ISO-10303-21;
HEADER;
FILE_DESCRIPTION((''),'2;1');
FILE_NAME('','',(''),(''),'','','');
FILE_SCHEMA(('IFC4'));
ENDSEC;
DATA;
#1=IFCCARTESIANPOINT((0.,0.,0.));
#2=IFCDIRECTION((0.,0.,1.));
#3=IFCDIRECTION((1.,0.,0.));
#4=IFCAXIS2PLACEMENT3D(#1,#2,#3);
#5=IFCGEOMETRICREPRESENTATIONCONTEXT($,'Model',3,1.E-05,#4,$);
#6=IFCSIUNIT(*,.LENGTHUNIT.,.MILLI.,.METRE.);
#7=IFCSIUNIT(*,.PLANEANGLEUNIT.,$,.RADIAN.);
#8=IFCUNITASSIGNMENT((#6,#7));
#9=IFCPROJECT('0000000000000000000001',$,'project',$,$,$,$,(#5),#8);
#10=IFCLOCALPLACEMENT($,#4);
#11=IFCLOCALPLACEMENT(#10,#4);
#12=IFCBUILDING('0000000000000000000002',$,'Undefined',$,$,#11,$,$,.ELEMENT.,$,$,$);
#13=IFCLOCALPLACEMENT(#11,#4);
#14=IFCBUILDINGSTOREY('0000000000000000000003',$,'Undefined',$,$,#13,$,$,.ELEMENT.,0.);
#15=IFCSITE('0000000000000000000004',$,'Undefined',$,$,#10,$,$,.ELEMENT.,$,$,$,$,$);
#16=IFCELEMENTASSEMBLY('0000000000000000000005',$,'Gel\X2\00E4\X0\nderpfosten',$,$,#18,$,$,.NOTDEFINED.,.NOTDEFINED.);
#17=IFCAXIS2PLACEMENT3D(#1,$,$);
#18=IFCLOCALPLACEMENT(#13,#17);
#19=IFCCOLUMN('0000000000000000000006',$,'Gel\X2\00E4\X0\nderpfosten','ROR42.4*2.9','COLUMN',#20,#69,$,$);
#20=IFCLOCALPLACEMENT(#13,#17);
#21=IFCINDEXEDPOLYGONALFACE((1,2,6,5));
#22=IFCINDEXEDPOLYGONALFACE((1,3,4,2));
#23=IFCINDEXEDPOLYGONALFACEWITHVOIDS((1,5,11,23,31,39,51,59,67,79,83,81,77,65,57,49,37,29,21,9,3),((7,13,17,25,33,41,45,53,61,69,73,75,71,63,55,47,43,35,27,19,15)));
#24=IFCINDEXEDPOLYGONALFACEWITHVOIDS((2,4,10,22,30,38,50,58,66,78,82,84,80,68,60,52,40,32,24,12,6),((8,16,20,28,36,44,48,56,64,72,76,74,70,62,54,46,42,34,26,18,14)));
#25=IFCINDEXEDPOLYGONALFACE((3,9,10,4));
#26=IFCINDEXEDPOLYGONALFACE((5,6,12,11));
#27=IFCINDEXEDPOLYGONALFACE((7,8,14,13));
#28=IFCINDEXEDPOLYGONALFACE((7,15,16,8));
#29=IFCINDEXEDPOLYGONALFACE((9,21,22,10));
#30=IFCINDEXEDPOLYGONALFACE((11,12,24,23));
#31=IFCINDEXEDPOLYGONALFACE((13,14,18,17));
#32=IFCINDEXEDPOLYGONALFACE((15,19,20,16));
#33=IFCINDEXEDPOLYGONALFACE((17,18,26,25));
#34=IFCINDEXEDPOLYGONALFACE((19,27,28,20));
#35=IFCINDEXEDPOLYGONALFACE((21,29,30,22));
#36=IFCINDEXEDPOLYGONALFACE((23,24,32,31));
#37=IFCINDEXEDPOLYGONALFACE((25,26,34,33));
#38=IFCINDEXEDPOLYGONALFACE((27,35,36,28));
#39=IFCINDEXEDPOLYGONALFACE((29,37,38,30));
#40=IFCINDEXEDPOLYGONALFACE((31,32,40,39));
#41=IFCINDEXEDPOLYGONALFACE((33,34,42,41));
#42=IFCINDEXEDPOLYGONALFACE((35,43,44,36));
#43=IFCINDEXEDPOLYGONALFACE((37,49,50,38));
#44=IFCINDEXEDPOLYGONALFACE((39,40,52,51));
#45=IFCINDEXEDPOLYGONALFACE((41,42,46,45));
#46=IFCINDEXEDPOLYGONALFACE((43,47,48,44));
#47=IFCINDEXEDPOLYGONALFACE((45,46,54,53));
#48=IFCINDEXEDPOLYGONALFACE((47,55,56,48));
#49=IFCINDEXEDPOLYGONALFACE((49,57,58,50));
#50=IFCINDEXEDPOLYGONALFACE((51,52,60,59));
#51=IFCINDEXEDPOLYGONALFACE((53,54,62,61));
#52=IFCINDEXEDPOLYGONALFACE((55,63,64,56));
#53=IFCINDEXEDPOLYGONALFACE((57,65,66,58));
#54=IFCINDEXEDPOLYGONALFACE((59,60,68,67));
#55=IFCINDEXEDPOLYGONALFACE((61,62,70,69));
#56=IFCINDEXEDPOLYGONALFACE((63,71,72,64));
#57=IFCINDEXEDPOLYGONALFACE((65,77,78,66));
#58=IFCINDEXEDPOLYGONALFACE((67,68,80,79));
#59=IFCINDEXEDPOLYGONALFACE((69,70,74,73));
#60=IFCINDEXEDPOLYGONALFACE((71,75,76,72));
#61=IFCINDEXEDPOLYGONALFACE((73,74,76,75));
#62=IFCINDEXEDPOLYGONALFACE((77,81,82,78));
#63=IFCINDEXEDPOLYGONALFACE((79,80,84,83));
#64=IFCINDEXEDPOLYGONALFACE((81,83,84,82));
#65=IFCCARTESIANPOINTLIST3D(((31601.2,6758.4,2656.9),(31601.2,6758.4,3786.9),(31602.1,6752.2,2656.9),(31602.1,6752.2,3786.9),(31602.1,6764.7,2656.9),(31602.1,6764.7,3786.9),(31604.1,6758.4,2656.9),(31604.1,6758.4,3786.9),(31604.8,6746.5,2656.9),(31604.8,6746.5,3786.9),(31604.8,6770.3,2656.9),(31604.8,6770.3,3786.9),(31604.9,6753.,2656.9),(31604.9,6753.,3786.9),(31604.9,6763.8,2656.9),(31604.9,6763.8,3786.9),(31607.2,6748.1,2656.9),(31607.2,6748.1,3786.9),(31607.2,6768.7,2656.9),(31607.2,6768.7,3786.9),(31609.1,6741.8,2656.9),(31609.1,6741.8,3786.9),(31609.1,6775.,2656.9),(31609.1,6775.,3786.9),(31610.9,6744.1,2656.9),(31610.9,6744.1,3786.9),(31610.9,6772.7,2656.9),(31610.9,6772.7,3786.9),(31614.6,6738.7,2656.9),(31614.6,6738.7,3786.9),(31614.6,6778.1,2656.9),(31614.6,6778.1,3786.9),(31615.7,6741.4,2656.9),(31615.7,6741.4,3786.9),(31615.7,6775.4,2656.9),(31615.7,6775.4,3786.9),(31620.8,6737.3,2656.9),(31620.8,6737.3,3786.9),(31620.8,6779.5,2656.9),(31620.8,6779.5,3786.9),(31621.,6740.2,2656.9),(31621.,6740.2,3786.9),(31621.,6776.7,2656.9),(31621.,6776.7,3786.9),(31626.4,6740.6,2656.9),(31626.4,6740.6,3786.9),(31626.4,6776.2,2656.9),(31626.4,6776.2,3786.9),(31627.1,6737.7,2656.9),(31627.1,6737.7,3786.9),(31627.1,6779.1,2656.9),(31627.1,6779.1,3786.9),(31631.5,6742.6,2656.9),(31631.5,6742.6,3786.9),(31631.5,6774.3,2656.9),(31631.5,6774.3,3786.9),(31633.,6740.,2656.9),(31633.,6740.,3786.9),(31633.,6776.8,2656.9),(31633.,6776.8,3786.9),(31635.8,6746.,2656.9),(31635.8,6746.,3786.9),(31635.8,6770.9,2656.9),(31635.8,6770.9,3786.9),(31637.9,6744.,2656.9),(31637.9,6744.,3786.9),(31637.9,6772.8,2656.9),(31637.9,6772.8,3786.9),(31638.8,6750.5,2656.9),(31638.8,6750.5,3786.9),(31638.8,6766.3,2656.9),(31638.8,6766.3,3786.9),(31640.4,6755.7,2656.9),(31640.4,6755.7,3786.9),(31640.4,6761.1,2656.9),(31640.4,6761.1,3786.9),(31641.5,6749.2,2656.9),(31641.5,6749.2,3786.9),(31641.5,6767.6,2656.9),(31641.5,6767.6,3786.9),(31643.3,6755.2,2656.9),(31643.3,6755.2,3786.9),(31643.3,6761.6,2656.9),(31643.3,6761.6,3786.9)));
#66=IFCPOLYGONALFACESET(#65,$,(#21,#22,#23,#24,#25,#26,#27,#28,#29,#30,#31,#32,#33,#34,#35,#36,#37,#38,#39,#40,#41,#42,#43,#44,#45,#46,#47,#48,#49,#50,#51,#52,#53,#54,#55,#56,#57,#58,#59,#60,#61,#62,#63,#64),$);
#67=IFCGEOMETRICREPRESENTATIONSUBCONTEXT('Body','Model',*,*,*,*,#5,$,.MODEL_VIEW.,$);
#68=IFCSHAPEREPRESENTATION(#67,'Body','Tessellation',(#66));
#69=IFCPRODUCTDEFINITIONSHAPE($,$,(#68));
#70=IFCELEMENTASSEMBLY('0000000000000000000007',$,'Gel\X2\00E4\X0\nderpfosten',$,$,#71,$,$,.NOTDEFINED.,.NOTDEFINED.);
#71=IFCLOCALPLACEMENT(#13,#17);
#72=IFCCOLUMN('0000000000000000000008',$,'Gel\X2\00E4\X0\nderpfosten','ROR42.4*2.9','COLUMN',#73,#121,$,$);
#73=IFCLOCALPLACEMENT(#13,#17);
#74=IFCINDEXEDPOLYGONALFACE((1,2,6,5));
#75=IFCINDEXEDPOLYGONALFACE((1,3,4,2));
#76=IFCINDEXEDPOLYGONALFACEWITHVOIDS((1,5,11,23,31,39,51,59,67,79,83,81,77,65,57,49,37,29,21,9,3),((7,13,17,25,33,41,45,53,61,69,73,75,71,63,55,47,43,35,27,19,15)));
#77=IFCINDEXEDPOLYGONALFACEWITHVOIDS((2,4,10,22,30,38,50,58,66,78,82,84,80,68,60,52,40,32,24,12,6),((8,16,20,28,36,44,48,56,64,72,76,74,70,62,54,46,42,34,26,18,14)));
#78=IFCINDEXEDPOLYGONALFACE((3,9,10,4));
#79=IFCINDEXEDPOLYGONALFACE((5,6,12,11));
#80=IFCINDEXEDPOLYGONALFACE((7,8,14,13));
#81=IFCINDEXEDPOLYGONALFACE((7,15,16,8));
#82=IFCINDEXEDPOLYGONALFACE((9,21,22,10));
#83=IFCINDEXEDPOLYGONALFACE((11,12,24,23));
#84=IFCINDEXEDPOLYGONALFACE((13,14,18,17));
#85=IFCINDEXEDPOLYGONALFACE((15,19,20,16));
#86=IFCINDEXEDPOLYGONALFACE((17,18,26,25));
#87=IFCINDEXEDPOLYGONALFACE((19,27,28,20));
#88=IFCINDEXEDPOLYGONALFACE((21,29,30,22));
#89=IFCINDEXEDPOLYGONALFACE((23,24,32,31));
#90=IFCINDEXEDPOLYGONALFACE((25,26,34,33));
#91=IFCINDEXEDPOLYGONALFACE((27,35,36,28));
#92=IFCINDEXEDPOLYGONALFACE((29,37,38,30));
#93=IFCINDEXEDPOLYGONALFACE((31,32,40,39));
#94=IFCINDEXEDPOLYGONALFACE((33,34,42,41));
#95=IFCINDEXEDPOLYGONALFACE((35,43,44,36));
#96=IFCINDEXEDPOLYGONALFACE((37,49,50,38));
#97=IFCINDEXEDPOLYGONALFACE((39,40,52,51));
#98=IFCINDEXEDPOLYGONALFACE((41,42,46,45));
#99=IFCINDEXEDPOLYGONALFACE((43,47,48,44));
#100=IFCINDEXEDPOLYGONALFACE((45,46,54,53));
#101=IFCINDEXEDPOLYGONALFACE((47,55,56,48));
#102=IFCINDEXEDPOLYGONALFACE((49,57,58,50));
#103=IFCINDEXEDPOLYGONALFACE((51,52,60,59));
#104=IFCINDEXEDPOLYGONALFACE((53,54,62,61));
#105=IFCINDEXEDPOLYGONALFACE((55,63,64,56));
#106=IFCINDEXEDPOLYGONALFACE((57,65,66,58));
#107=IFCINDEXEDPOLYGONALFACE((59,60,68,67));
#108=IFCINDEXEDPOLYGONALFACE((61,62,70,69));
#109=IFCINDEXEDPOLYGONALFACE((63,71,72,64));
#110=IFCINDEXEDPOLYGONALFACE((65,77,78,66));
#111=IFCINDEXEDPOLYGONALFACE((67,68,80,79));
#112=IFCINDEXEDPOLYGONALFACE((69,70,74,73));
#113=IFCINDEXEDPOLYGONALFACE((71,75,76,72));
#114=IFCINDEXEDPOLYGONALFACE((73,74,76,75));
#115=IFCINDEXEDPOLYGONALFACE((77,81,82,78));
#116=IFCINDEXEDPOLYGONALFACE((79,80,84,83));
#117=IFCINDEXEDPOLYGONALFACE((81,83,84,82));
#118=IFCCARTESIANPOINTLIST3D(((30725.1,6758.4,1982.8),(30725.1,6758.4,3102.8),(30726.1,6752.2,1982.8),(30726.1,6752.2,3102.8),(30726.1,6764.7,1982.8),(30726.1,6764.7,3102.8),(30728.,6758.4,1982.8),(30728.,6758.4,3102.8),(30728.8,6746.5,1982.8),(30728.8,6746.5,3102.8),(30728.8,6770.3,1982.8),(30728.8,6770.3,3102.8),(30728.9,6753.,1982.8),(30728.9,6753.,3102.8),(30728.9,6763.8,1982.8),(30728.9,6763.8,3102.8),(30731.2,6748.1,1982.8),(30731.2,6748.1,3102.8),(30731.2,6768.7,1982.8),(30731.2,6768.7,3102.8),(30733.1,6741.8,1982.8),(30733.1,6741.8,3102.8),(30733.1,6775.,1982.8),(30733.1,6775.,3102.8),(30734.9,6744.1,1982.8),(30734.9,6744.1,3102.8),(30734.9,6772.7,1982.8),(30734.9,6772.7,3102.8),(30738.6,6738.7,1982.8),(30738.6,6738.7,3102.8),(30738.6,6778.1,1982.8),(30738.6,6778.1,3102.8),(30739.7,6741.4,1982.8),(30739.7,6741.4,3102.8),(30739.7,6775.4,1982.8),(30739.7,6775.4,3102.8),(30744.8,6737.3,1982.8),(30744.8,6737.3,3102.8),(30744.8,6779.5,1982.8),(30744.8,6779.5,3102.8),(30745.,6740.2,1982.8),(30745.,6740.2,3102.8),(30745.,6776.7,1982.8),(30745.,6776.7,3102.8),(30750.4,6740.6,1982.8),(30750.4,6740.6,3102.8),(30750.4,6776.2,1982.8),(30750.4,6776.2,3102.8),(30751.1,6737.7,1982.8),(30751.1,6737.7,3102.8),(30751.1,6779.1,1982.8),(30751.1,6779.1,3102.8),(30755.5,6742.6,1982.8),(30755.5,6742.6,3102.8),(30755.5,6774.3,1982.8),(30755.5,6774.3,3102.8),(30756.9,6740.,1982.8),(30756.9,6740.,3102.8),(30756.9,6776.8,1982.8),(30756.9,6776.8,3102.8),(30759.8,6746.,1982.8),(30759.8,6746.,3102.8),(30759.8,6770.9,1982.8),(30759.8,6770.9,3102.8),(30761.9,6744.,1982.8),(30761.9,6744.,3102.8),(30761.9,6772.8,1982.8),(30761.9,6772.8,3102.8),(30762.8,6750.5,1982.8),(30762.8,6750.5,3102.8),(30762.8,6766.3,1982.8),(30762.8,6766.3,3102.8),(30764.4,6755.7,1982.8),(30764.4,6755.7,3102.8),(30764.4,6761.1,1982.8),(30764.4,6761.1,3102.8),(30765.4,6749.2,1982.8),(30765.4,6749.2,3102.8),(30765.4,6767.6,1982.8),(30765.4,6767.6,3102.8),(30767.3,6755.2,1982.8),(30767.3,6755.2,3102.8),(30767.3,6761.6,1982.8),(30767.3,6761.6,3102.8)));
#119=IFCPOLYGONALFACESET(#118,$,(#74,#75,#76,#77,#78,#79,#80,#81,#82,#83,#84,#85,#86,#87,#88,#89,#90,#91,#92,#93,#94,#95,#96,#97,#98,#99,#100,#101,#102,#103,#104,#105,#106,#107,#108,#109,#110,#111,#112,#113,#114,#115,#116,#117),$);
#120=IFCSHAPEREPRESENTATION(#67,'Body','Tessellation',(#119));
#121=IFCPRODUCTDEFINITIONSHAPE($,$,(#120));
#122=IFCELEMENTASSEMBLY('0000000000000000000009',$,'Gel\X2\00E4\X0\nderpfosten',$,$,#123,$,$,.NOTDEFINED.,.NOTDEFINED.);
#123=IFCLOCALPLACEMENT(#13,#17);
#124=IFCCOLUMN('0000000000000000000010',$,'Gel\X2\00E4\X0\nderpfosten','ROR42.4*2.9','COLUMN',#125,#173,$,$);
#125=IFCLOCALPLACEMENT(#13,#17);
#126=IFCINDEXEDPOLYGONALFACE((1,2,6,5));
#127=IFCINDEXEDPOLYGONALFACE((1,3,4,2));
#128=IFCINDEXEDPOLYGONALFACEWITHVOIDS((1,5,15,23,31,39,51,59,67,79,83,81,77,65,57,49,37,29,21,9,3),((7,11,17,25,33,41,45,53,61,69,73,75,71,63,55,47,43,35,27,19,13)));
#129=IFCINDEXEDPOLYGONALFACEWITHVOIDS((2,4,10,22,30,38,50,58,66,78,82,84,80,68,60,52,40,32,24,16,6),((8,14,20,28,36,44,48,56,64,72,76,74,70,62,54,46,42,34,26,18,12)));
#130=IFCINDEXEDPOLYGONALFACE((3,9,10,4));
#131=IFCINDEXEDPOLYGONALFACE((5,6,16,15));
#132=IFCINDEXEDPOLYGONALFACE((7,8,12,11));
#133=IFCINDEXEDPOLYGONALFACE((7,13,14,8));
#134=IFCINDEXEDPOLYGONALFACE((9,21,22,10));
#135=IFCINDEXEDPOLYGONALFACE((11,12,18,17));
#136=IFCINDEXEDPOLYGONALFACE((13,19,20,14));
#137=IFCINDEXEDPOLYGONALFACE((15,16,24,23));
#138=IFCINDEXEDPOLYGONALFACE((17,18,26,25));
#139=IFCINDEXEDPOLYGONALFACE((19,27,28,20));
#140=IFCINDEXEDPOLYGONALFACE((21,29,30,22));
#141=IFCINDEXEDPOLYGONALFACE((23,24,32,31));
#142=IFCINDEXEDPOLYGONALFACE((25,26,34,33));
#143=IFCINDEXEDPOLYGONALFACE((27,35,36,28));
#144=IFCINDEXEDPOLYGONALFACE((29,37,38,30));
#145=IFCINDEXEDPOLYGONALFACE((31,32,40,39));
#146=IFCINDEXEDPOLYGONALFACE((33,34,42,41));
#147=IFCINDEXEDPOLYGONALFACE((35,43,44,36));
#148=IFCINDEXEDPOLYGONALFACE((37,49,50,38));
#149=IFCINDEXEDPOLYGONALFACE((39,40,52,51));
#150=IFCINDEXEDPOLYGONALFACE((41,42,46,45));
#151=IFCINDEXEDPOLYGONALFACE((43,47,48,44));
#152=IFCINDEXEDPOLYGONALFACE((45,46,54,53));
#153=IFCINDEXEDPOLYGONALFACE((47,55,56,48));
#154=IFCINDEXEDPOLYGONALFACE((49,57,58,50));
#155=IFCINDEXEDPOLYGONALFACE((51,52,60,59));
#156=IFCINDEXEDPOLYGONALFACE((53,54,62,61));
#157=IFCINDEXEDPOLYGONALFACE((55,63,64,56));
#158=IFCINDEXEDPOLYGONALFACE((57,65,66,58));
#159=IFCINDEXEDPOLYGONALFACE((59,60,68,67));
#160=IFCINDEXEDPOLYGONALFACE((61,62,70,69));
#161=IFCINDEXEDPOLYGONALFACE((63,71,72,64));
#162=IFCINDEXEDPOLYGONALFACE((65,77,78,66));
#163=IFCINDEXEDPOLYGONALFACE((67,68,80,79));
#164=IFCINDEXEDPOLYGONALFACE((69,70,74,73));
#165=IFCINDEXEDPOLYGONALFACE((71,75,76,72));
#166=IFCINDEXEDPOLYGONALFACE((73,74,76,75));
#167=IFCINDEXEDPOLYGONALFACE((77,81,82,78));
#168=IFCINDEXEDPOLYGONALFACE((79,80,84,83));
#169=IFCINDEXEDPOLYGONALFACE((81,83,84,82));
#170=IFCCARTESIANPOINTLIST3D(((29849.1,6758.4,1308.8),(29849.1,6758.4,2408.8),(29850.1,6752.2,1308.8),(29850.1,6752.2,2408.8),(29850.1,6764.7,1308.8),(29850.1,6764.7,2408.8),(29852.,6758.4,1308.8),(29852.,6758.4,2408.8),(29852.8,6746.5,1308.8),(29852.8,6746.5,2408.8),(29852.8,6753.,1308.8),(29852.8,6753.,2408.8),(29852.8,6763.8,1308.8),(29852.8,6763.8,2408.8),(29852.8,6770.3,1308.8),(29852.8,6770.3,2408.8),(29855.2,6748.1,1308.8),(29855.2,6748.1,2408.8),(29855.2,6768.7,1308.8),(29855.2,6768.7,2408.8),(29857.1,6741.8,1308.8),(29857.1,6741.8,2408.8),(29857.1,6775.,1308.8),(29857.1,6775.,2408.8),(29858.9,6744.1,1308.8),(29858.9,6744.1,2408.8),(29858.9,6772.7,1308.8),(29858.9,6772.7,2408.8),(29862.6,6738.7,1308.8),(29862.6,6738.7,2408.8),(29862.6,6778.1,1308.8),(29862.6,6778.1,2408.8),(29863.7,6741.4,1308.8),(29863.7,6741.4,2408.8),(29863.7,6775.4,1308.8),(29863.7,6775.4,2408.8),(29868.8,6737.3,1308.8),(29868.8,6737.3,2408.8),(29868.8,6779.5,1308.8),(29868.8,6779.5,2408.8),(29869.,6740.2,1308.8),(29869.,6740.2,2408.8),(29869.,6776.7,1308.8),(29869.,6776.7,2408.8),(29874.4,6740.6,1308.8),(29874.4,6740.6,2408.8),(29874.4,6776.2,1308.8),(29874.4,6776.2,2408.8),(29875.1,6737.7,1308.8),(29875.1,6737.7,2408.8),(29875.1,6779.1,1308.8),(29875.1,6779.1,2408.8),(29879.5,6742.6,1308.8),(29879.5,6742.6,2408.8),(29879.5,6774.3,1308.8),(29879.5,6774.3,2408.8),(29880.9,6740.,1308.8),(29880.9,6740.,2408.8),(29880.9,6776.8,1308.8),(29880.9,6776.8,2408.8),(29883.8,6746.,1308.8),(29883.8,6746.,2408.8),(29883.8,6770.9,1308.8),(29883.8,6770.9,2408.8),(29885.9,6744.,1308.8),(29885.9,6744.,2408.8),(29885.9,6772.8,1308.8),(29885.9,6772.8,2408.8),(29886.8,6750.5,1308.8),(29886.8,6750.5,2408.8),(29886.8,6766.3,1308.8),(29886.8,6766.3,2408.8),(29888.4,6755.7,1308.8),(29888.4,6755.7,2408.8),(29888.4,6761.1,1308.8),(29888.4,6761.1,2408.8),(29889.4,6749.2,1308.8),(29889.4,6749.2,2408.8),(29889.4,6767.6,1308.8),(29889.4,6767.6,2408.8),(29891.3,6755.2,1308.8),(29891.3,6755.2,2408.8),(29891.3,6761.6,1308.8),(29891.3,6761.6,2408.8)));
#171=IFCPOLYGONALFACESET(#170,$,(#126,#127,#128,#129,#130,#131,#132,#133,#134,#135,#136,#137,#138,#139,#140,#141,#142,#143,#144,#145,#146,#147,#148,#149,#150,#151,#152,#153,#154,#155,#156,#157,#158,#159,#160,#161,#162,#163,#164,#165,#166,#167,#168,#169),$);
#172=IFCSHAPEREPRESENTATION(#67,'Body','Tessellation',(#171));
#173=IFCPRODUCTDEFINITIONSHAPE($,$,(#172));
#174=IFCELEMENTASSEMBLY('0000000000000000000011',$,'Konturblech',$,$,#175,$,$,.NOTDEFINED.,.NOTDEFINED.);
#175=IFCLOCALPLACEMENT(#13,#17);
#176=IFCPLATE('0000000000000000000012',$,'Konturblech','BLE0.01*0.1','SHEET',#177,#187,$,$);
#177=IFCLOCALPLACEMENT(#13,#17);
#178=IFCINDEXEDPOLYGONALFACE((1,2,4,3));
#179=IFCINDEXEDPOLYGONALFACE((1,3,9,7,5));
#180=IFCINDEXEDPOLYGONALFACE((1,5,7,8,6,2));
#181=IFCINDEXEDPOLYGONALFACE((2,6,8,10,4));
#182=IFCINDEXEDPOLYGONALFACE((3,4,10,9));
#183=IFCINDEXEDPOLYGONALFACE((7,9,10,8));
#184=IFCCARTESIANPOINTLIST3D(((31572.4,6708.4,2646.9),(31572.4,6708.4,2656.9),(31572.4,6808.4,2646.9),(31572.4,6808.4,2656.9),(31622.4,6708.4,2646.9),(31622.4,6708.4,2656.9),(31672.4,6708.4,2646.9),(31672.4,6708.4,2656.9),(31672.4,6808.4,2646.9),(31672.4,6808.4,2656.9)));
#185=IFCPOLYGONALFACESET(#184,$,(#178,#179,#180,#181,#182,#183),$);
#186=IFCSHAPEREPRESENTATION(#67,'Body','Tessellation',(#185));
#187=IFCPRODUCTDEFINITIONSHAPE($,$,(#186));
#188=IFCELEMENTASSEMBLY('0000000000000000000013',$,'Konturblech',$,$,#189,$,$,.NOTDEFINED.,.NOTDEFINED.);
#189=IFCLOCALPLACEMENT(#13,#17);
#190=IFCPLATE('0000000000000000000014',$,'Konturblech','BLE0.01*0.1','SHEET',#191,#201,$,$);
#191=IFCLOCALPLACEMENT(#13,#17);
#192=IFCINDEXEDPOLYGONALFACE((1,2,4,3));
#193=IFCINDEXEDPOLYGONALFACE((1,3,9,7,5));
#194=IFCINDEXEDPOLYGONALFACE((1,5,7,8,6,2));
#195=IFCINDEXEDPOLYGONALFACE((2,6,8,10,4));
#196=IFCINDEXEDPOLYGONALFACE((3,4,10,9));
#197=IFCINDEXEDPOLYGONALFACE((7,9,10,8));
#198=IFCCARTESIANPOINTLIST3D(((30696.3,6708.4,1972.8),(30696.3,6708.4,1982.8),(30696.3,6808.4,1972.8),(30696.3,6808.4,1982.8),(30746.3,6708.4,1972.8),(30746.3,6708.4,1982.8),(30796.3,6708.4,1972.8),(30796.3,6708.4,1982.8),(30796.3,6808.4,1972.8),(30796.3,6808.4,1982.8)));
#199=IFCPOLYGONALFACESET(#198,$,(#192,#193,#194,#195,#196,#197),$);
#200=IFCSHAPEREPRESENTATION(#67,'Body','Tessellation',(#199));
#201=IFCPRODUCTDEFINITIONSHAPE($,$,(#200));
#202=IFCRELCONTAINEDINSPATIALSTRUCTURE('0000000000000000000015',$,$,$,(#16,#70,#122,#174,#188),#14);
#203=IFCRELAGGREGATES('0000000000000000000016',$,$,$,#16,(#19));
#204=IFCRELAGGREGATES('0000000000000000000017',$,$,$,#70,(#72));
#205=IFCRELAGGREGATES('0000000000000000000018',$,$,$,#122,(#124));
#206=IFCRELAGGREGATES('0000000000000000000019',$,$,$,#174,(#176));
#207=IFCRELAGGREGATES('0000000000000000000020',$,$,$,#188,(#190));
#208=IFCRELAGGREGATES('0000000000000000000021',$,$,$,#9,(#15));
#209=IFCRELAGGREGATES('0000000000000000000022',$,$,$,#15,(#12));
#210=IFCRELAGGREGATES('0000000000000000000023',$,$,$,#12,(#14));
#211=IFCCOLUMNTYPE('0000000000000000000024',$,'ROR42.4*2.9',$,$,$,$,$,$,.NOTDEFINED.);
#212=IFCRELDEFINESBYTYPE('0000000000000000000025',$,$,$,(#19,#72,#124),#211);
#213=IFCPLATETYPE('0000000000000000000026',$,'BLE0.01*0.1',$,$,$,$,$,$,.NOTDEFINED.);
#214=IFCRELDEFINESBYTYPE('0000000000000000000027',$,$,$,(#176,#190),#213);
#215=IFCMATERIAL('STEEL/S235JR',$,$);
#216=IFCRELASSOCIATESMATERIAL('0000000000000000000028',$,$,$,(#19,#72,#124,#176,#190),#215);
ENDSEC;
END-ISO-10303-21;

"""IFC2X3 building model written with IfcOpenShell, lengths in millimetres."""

from ifc_helpers import new_model, si_unit, frame, origin_with_axes, origin_2d_with_axis, place, context, subcontext, project, spatial, polyline, hollow_circle, outline, extrude, material, type_object, element, aggregate, save


model = new_model("IFC2X3")

# Units and contexts
model_context = context("Model", 3, precision=1e-05, world=origin_with_axes())
body_context = subcontext(model_context, "Body", "Model", "MODEL_VIEW")
ifc_project = project(units=[si_unit("LENGTHUNIT", "METRE", prefix="MILLI"), si_unit("PLANEANGLEUNIT", "RADIAN")], contexts=[model_context])

# Site, building, storey
site_placement = place(None, origin_with_axes())
site = spatial("IfcSite", under=ifc_project, at=site_placement, Name="Undefined", CompositionType="ELEMENT")
building_placement = place(site_placement, origin_with_axes())
building = spatial("IfcBuilding", under=site, at=building_placement, Name="Undefined", CompositionType="ELEMENT")
storey_placement = place(building_placement, origin_with_axes())
storey = spatial("IfcBuildingStorey", under=building, at=storey_placement, Name="Undefined", CompositionType="ELEMENT", Elevation=0.0)

# Element assemblies, columns
assembly_1_placement = place(storey_placement, origin_with_axes())
assembly_1 = element("IfcElementAssembly", 1, at=assembly_1_placement, inside=storey, Name="Geländerpfosten", AssemblyPlace="NOTDEFINED", PredefinedType="NOTDEFINED")
ifc_material_1 = material(Name="STEEL/S235JR")
column_type = type_object("IfcColumnType", Name="ROR42.4*2.9", PredefinedType="NOTDEFINED")
column_1_placement = place(assembly_1_placement, frame((31622.4, 6758.4, 2656.9), z_axis=(0.0, 0.0, 1.0), x_axis=(0.0, 1.0, 0.0)))
column_1 = element("IfcColumn", 2, at=column_1_placement, type_object=column_type, material=ifc_material_1, Name="Geländerpfosten", Description="ROR42.4*2.9", ObjectType="COLUMN", context=body_context, shape_type="SweptSolid", body=[
    extrude(hollow_circle(Radius=21.2, WallThickness=2.9, at=origin_2d_with_axis()), frame((0.0, 0.0, 1130.0), z_axis=(0.0, 0.0, -1.0), x_axis=(0.0, 1.0, 0.0)), (0.0, 0.0, 1.0), 1130.0),
])
aggregate(assembly_1, [column_1])
assembly_2_placement = place(storey_placement, origin_with_axes())
assembly_2 = element("IfcElementAssembly", 3, at=assembly_2_placement, inside=storey, Name="Geländerpfosten", AssemblyPlace="NOTDEFINED", PredefinedType="NOTDEFINED")
column_2_placement = place(assembly_2_placement, frame((30746.3, 6758.4, 1982.8), z_axis=(0.0, 0.0, 1.0), x_axis=(0.0, 1.0, 0.0)))
column_2 = element("IfcColumn", 4, at=column_2_placement, type_object=column_type, material=ifc_material_1, Name="Geländerpfosten", Description="ROR42.4*2.9", ObjectType="COLUMN", context=body_context, shape_type="SweptSolid", body=[
    extrude(hollow_circle(Radius=21.2, WallThickness=2.9, at=origin_2d_with_axis()), frame((0.0, 0.0, 1120.0), z_axis=(0.0, 0.0, -1.0), x_axis=(0.0, 1.0, 0.0)), (0.0, 0.0, 1.0), 1120.0),
])
aggregate(assembly_2, [column_2])
assembly_3_placement = place(storey_placement, origin_with_axes())
assembly_3 = element("IfcElementAssembly", 5, at=assembly_3_placement, inside=storey, Name="Geländerpfosten", AssemblyPlace="NOTDEFINED", PredefinedType="NOTDEFINED")
column_3_placement = place(assembly_3_placement, frame((29870.3, 6758.4, 1308.8), z_axis=(0.0, 0.0, 1.0), x_axis=(0.0, 1.0, 0.0)))
column_3 = element("IfcColumn", 6, at=column_3_placement, type_object=column_type, material=ifc_material_1, Name="Geländerpfosten", Description="ROR42.4*2.9", ObjectType="COLUMN", context=body_context, shape_type="SweptSolid", body=[
    extrude(hollow_circle(Radius=21.2, WallThickness=2.9, at=origin_2d_with_axis()), frame((0.0, 0.0, 1100.0), z_axis=(0.0, 0.0, -1.0), x_axis=(0.0, 1.0, 0.0)), (0.0, 0.0, 1.0), 1100.0),
])
aggregate(assembly_3, [column_3])

# Element assemblies, plates
assembly_4_placement = place(storey_placement, origin_with_axes())
assembly_4 = element("IfcElementAssembly", 7, at=assembly_4_placement, inside=storey, Name="Konturblech", AssemblyPlace="NOTDEFINED", PredefinedType="NOTDEFINED")
plate_type = type_object("IfcPlateType", Name="BLE0.01*0.1", PredefinedType="NOTDEFINED")
plate_1_placement = place(assembly_4_placement, frame((31622.4, 6708.4, 2651.9), z_axis=(0.0, 0.0, 1.0), x_axis=(1.0, 0.0, 0.0)))
plate_1 = element("IfcPlate", 8, at=plate_1_placement, type_object=plate_type, material=ifc_material_1, Name="Konturblech", Description="BLE0.01*0.1", ObjectType="SHEET", context=body_context, shape_type="SweptSolid", body=[
    extrude(outline(polyline([(0.0, 0.0), (50.0, 0.0), (50.0, 100.0), (-50.0, 100.0), (-50.0, 0.0), (0.0, 0.0)])), frame((0.0, 0.0, -5.0), z_axis=(0.0, 0.0, 1.0), x_axis=(1.0, 0.0, 0.0)), (0.0, 0.0, 1.0), 10.0),
])
aggregate(assembly_4, [plate_1])
assembly_5_placement = place(storey_placement, origin_with_axes())
assembly_5 = element("IfcElementAssembly", 9, at=assembly_5_placement, inside=storey, Name="Konturblech", AssemblyPlace="NOTDEFINED", PredefinedType="NOTDEFINED")
plate_2_placement = place(assembly_5_placement, frame((30746.3, 6708.4, 1977.8), z_axis=(0.0, 0.0, 1.0), x_axis=(1.0, 0.0, 0.0)))
plate_2 = element("IfcPlate", 10, at=plate_2_placement, type_object=plate_type, material=ifc_material_1, Name="Konturblech", Description="BLE0.01*0.1", ObjectType="SHEET", context=body_context, shape_type="SweptSolid", body=[
    extrude(outline(polyline([(0.0, 0.0), (50.0, 0.0), (50.0, 100.0), (-50.0, 100.0), (-50.0, 0.0), (0.0, 0.0)])), frame((0.0, 0.0, -5.0), z_axis=(0.0, 0.0, 1.0), x_axis=(1.0, 0.0, 0.0)), (0.0, 0.0, 1.0), 10.0),
])

aggregate(assembly_5, [plate_2])

save(model, "model.ifc")
